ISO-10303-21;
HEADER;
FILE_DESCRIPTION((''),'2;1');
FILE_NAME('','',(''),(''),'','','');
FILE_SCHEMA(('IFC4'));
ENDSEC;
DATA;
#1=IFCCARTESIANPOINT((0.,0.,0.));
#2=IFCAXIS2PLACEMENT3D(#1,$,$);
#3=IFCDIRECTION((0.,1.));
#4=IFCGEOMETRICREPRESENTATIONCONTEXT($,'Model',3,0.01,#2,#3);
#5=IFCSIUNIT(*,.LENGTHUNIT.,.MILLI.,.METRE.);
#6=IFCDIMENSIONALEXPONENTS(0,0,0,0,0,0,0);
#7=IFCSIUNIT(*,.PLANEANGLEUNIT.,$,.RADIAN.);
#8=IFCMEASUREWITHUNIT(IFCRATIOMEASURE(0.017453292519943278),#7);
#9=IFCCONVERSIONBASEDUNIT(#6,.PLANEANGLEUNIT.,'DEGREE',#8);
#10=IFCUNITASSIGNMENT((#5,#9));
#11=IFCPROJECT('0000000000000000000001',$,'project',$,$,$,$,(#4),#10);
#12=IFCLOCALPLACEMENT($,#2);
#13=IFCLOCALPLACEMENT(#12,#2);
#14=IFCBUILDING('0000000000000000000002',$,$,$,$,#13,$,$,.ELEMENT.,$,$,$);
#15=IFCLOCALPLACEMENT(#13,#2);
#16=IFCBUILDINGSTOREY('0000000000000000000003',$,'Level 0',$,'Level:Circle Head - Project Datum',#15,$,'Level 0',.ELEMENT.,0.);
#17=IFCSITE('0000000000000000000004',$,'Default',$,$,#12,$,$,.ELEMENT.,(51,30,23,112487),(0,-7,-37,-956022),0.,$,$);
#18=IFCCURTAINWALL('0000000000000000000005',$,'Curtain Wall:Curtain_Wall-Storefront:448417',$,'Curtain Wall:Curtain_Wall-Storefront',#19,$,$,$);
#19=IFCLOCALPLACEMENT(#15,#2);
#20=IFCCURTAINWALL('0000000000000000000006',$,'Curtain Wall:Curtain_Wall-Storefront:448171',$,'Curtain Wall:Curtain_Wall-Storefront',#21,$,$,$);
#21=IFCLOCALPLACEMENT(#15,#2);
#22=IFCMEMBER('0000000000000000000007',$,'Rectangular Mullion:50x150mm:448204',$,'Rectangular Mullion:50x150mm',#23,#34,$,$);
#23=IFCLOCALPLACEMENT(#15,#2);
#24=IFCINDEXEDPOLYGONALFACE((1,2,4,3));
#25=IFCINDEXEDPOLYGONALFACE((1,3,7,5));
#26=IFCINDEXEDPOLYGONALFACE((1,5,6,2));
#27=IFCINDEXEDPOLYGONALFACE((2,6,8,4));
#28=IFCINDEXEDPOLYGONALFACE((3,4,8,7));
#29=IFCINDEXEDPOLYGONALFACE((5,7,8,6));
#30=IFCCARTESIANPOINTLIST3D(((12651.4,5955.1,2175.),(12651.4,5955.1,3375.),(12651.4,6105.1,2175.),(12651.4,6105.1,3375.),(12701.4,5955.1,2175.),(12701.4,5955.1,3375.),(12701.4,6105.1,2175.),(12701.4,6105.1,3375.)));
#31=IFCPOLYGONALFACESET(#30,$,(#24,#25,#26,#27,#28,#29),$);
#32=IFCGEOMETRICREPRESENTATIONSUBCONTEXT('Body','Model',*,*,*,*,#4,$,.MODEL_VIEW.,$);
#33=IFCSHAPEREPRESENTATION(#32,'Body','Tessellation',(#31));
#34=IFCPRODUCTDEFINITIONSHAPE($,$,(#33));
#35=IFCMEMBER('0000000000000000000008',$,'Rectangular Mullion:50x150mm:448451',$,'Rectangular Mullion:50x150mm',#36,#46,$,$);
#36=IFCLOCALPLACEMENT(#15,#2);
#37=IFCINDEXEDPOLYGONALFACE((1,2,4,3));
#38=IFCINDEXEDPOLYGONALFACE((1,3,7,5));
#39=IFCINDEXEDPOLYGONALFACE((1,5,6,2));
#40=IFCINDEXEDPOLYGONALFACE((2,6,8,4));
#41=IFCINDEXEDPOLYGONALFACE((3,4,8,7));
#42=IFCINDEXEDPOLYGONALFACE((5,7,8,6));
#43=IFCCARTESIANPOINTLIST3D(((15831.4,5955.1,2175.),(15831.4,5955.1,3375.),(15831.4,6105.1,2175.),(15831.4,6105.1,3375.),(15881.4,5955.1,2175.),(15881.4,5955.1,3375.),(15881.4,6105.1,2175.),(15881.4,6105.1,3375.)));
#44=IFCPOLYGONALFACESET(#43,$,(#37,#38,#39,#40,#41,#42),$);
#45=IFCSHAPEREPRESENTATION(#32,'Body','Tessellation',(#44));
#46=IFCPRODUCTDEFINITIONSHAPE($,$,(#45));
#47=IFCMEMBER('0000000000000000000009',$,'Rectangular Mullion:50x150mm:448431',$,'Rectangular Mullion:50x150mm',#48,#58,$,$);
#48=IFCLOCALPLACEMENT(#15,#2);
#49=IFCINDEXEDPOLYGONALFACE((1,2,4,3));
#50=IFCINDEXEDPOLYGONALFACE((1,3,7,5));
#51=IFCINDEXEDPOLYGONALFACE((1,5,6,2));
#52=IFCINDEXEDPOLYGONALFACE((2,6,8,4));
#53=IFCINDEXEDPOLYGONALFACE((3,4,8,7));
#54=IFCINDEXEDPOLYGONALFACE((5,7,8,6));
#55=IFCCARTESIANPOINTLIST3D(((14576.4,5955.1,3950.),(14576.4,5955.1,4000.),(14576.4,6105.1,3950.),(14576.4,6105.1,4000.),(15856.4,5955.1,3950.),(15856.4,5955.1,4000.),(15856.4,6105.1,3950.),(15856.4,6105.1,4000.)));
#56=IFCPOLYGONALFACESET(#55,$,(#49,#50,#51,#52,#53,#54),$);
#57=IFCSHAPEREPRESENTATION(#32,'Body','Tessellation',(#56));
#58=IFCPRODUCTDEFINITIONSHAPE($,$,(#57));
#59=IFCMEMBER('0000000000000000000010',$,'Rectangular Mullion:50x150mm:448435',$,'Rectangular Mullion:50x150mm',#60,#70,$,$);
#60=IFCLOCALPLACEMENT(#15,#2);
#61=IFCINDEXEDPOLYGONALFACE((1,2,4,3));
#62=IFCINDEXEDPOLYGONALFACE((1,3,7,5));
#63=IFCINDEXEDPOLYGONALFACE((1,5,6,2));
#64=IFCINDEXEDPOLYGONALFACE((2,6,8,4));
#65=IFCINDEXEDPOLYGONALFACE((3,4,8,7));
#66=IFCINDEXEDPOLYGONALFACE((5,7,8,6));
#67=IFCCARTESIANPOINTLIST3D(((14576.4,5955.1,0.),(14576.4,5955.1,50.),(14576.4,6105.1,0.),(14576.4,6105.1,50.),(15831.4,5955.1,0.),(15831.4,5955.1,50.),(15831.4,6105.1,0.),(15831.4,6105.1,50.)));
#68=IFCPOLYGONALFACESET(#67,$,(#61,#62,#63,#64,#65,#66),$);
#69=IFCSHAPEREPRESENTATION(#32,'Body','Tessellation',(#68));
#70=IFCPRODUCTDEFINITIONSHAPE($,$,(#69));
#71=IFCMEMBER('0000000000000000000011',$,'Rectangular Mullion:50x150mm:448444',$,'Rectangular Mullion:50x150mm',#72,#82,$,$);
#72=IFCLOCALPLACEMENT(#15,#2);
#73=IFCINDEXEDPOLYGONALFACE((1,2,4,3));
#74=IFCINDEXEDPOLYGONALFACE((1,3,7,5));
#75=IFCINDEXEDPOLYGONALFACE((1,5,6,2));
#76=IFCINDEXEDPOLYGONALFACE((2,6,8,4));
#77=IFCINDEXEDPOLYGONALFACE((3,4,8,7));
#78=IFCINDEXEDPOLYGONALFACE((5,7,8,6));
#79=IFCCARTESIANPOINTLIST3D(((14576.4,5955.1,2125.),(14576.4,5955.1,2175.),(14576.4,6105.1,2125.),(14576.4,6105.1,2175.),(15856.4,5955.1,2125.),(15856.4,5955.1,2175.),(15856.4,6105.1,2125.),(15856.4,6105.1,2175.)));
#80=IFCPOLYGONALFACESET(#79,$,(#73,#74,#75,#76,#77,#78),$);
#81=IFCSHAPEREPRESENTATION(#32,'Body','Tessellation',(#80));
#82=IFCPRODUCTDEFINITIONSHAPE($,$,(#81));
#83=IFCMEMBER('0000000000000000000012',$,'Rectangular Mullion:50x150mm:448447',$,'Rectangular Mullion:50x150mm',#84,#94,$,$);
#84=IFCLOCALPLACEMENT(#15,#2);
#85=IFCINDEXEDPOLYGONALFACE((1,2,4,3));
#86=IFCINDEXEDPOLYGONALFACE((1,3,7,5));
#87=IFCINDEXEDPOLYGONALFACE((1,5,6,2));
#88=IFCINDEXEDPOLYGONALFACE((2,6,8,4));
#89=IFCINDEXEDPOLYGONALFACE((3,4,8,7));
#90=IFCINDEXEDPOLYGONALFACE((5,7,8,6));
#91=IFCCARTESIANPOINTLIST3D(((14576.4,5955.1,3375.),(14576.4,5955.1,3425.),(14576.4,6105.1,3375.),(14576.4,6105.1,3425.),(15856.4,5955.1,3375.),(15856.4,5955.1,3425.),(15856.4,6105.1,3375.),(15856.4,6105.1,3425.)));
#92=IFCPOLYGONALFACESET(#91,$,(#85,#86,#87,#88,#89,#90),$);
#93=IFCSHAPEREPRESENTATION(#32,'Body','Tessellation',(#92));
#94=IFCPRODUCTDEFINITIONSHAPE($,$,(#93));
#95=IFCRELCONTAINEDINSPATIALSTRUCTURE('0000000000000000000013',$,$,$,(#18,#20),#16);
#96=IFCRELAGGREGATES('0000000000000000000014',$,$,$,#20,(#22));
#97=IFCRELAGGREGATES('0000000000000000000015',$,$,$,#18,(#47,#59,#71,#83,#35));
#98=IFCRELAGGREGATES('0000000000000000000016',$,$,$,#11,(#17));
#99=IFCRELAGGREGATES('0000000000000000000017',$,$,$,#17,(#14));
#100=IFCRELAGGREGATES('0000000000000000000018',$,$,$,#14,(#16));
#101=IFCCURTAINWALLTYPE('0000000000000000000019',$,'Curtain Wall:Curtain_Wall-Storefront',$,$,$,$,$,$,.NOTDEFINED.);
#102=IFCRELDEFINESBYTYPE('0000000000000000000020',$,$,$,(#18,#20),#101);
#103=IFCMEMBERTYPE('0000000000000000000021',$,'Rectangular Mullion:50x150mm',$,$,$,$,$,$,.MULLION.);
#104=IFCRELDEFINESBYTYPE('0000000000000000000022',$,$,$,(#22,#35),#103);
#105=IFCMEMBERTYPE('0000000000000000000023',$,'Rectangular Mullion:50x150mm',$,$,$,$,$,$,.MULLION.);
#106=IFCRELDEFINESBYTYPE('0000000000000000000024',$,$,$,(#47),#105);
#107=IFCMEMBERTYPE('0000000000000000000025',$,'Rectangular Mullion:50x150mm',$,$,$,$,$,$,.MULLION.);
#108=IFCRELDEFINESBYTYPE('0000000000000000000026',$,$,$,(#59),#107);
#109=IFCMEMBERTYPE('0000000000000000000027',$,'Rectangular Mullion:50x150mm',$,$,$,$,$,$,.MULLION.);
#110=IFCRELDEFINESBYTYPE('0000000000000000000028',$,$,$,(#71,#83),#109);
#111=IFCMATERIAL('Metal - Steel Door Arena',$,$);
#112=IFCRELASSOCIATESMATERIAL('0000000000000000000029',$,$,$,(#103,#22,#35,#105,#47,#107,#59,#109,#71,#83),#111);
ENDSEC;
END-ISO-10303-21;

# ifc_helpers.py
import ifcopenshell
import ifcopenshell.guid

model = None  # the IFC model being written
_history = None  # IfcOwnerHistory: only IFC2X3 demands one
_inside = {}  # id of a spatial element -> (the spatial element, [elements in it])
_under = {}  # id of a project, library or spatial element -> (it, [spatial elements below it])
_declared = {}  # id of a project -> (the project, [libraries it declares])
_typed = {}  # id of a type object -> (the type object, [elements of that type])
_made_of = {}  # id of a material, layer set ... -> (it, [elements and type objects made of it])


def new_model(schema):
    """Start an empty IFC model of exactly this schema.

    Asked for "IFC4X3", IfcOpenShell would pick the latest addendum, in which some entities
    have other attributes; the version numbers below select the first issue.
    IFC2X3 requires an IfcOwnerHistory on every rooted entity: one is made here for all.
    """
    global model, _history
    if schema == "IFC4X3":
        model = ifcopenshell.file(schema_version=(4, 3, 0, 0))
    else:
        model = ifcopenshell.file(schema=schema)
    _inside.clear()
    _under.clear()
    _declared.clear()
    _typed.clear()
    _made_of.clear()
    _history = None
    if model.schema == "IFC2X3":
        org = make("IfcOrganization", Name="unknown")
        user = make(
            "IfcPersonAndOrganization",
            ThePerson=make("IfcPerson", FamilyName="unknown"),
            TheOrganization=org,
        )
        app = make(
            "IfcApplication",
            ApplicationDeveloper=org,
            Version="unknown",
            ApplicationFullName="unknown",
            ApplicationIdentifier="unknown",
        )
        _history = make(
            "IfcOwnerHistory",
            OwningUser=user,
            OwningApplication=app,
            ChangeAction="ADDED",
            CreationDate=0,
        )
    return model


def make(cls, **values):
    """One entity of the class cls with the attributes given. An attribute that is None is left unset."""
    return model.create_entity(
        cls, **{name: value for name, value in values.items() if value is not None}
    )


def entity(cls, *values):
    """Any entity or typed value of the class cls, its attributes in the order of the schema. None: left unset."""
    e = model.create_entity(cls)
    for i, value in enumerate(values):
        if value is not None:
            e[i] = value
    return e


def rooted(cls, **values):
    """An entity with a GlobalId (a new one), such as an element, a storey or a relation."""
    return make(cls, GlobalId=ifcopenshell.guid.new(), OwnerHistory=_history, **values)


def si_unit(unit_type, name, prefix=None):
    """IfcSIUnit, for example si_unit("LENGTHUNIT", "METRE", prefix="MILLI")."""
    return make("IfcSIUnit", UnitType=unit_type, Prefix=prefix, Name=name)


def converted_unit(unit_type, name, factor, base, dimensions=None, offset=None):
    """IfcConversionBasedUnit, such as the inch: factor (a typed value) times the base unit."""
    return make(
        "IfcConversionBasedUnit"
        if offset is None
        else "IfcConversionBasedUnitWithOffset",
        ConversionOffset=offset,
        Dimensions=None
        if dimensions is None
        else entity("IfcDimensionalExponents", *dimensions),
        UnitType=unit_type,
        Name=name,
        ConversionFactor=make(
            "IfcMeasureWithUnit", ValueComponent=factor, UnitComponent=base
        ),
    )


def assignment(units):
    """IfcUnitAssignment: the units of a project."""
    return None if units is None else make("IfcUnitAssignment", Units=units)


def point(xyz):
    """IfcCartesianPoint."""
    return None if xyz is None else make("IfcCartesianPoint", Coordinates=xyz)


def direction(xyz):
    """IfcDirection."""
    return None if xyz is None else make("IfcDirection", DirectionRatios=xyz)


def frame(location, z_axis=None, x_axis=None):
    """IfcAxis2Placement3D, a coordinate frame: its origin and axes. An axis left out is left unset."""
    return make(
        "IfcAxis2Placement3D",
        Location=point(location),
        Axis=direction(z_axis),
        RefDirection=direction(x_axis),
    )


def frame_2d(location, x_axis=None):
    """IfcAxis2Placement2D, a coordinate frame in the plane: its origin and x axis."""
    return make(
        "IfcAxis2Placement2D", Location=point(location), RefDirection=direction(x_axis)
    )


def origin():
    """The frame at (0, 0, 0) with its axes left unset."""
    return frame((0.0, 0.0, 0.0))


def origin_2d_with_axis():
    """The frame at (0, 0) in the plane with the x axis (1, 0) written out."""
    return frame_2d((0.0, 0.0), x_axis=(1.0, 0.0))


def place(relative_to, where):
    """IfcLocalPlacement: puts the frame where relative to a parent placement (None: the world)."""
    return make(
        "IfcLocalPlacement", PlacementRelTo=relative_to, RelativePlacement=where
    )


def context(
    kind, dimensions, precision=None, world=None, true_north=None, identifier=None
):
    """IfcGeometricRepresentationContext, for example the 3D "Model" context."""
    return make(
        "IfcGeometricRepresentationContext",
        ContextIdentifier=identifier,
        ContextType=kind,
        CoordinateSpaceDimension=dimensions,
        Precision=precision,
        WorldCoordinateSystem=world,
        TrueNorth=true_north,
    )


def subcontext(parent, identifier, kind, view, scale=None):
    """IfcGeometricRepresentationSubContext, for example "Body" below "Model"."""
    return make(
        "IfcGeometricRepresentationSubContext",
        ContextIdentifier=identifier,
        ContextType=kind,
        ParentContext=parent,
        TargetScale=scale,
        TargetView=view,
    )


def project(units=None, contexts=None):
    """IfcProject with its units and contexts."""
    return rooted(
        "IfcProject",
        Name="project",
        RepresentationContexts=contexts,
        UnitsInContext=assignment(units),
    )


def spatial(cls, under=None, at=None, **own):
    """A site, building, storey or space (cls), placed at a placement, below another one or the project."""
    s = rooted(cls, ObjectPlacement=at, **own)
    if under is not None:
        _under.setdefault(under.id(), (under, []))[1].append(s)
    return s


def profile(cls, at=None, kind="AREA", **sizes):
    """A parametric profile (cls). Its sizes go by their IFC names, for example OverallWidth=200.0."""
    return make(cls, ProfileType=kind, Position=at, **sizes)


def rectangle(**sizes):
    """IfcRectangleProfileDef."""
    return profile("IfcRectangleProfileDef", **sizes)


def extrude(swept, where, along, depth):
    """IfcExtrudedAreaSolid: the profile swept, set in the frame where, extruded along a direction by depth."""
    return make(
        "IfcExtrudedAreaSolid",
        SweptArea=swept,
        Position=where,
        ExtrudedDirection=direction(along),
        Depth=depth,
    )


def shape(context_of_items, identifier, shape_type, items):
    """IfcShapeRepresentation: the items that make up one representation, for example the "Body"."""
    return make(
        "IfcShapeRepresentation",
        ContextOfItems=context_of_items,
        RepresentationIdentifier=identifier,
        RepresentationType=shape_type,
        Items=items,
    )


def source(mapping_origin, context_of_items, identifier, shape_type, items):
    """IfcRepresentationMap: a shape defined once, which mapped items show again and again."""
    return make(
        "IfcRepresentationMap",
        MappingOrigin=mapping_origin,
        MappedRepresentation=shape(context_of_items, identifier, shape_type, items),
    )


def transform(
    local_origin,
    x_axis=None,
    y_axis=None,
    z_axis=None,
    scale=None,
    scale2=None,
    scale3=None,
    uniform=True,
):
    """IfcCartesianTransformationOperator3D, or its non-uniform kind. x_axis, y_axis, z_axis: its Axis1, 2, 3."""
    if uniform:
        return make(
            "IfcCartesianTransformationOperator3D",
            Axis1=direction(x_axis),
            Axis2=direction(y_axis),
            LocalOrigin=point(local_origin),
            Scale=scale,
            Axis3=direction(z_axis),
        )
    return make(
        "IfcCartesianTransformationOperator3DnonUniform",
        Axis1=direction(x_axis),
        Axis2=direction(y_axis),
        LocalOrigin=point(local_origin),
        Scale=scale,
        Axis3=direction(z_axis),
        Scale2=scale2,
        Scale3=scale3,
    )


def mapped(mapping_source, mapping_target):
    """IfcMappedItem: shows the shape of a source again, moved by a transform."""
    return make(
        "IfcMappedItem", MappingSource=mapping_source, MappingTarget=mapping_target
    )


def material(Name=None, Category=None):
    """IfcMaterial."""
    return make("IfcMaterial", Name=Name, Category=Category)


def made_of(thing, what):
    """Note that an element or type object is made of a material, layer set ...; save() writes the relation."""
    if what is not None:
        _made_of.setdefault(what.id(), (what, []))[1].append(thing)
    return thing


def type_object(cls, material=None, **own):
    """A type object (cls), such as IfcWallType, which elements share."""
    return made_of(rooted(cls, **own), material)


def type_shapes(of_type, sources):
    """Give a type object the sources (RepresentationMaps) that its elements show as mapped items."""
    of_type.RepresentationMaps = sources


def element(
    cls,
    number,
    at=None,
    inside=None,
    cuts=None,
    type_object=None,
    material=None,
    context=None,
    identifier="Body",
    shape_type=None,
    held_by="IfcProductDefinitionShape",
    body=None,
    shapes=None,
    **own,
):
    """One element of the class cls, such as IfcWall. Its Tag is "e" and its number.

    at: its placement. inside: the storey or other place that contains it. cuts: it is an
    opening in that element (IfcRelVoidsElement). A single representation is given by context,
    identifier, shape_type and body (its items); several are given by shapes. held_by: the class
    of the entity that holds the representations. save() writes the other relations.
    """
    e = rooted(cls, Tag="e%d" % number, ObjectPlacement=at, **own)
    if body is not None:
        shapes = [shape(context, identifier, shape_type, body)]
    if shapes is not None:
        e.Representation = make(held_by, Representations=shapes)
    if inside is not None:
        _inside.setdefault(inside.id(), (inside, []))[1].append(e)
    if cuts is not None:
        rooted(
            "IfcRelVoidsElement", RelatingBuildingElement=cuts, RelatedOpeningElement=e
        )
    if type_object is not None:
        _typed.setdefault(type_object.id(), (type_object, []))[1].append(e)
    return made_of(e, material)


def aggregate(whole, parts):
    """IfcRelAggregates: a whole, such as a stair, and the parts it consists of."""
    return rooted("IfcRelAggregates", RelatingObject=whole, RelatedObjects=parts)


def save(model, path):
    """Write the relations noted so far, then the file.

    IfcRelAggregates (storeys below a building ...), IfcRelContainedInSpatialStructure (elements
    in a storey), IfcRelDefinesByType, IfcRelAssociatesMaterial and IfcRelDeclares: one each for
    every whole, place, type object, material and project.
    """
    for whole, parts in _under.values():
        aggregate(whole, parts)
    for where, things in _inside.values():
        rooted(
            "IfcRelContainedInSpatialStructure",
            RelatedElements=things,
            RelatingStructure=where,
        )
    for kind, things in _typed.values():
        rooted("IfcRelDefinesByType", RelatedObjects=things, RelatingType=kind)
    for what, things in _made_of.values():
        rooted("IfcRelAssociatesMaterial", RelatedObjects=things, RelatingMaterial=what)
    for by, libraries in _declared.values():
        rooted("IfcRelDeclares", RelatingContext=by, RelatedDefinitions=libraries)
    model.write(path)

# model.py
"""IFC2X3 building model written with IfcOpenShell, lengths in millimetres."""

from ifc_helpers import new_model, entity, si_unit, converted_unit, direction, frame, origin, origin_2d_with_axis, place, context, subcontext, project, spatial, rectangle, extrude, source, transform, mapped, material, type_object, type_shapes, element, aggregate, save


model = new_model("IFC2X3")

# Units and contexts
model_context = context("Model", 3, precision=0.01, world=origin(), true_north=direction((0.0, 1.0)))
body_context = subcontext(model_context, "Body", "Model", "MODEL_VIEW")
ifc_project = project(units=[si_unit("LENGTHUNIT", "METRE", prefix="MILLI"), converted_unit("PLANEANGLEUNIT", "DEGREE", entity("IfcRatioMeasure", 0.017453292519943278), si_unit("PLANEANGLEUNIT", "RADIAN"), dimensions=[0, 0, 0, 0, 0, 0, 0])], contexts=[model_context])

# Site, building, storey
site_placement = place(None, origin())
site = spatial("IfcSite", under=ifc_project, at=site_placement, Name="Default", CompositionType="ELEMENT", RefLatitude=(51, 30, 23, 112487), RefLongitude=(0, -7, -37, -956022), RefElevation=0.0)
building_placement = place(site_placement, origin())
building = spatial("IfcBuilding", under=site, at=building_placement, CompositionType="ELEMENT")
storey_placement = place(building_placement, origin())
storey = spatial("IfcBuildingStorey", under=building, at=storey_placement, Name="Level 0", ObjectType="Level:Circle Head - Project Datum", LongName="Level 0", CompositionType="ELEMENT", Elevation=0.0)

# Curtain walls
curtain_wall_type = type_object("IfcCurtainWallType", Name="Curtain Wall:Curtain_Wall-Storefront", PredefinedType="NOTDEFINED")
curtain_wall_1_placement = place(storey_placement, origin())
curtain_wall_1 = element("IfcCurtainWall", 1, at=curtain_wall_1_placement, inside=storey, type_object=curtain_wall_type, Name="Curtain Wall:Curtain_Wall-Storefront:448417", ObjectType="Curtain Wall:Curtain_Wall-Storefront")
ifc_material_1 = material(Name="Metal - Steel Door Arena")
curtain_wall_2_placement = place(storey_placement, origin())
curtain_wall_2 = element("IfcCurtainWall", 2, at=curtain_wall_2_placement, inside=storey, type_object=curtain_wall_type, Name="Curtain Wall:Curtain_Wall-Storefront:448171", ObjectType="Curtain Wall:Curtain_Wall-Storefront")

# Members
member_type_1 = type_object("IfcMemberType", Name="Rectangular Mullion:50x150mm", PredefinedType="MULLION", material=ifc_material_1)
shared_shape_1 = source(origin(), body_context, "Body", "SweptSolid", [
    extrude(rectangle(XDim=150.0, YDim=50.0, at=origin_2d_with_axis()), frame((0.0, 0.0, -1200.0), z_axis=(0.0, 0.0, 1.0), x_axis=(0.0, -1.0, 0.0)), (0.0, 0.0, 1.0), 1200.0),
])
type_shapes(member_type_1, [shared_shape_1])
member_1_placement = place(curtain_wall_2_placement, frame((12676.4, 6030.1, 2175.0), z_axis=(0.0, 0.0, -1.0), x_axis=(-1.0, 0.0, 0.0)))
member_1 = element("IfcMember", 3, at=member_1_placement, type_object=member_type_1, material=ifc_material_1, Name="Rectangular Mullion:50x150mm:448204", ObjectType="Rectangular Mullion:50x150mm", context=body_context, shape_type="MappedRepresentation", body=[
    mapped(shared_shape_1, transform((0.0, 0.0, 0.0), scale=1.0)),
])
member_2_placement = place(curtain_wall_1_placement, frame((15856.4, 6030.1, 2175.0), z_axis=(0.0, 0.0, -1.0), x_axis=(-1.0, 0.0, 0.0)))
member_2 = element("IfcMember", 4, at=member_2_placement, type_object=member_type_1, material=ifc_material_1, Name="Rectangular Mullion:50x150mm:448451", ObjectType="Rectangular Mullion:50x150mm", context=body_context, shape_type="MappedRepresentation", body=[
    mapped(shared_shape_1, transform((0.0, 0.0, 0.0), scale=1.0)),
])
member_type_2 = type_object("IfcMemberType", Name="Rectangular Mullion:50x150mm", PredefinedType="MULLION", material=ifc_material_1)
shared_shape_2 = source(origin(), body_context, "Body", "SweptSolid", [
    extrude(rectangle(XDim=150.0, YDim=50.0, at=origin_2d_with_axis()), frame((-25.0, 0.0, -1280.0), z_axis=(0.0, 0.0, 1.0), x_axis=(0.0, -1.0, 0.0)), (0.0, 0.0, 1.0), 1280.0),
])
type_shapes(member_type_2, [shared_shape_2])
member_3_placement = place(curtain_wall_1_placement, frame((14576.4, 6030.1, 4000.0), z_axis=(-1.0, 0.0, 0.0), x_axis=(0.0, 0.0, 1.0)))
member_3 = element("IfcMember", 5, at=member_3_placement, type_object=member_type_2, material=ifc_material_1, Name="Rectangular Mullion:50x150mm:448431", ObjectType="Rectangular Mullion:50x150mm", context=body_context, shape_type="MappedRepresentation", body=[
    mapped(shared_shape_2, transform((0.0, 0.0, 0.0), scale=1.0)),
])
member_type_3 = type_object("IfcMemberType", Name="Rectangular Mullion:50x150mm", PredefinedType="MULLION", material=ifc_material_1)
shared_shape_3 = source(origin(), body_context, "Body", "SweptSolid", [
    extrude(rectangle(XDim=150.0, YDim=50.0, at=origin_2d_with_axis()), frame((-25.0, 0.0, -1255.0), z_axis=(0.0, 0.0, 1.0), x_axis=(0.0, -1.0, 0.0)), (0.0, 0.0, 1.0), 1255.0),
])
type_shapes(member_type_3, [shared_shape_3])
member_4_placement = place(curtain_wall_1_placement, frame((15831.4, 6030.1, 0.0), z_axis=(1.0, 0.0, 0.0), x_axis=(0.0, 0.0, -1.0)))
member_4 = element("IfcMember", 6, at=member_4_placement, type_object=member_type_3, material=ifc_material_1, Name="Rectangular Mullion:50x150mm:448435", ObjectType="Rectangular Mullion:50x150mm", context=body_context, shape_type="MappedRepresentation", body=[
    mapped(shared_shape_3, transform((0.0, 0.0, 0.0), scale=1.0)),
])
member_type_4 = type_object("IfcMemberType", Name="Rectangular Mullion:50x150mm", PredefinedType="MULLION", material=ifc_material_1)
shared_shape_4 = source(origin(), body_context, "Body", "SweptSolid", [
    extrude(rectangle(XDim=150.0, YDim=50.0, at=origin_2d_with_axis()), frame((0.0, 0.0, -1280.0), z_axis=(0.0, 0.0, 1.0), x_axis=(0.0, -1.0, 0.0)), (0.0, 0.0, 1.0), 1280.0),
])
type_shapes(member_type_4, [shared_shape_4])
member_5_placement = place(curtain_wall_1_placement, frame((14576.4, 6030.1, 2150.0), z_axis=(-1.0, 0.0, 0.0), x_axis=(0.0, 0.0, 1.0)))
member_5 = element("IfcMember", 7, at=member_5_placement, type_object=member_type_4, material=ifc_material_1, Name="Rectangular Mullion:50x150mm:448444", ObjectType="Rectangular Mullion:50x150mm", context=body_context, shape_type="MappedRepresentation", body=[
    mapped(shared_shape_4, transform((0.0, 0.0, 0.0), scale=1.0)),
])
member_6_placement = place(curtain_wall_1_placement, frame((14576.4, 6030.1, 3400.0), z_axis=(-1.0, 0.0, 0.0), x_axis=(0.0, 0.0, 1.0)))
member_6 = element("IfcMember", 8, at=member_6_placement, type_object=member_type_4, material=ifc_material_1, Name="Rectangular Mullion:50x150mm:448447", ObjectType="Rectangular Mullion:50x150mm", context=body_context, shape_type="MappedRepresentation", body=[
    mapped(shared_shape_4, transform((0.0, 0.0, 0.0), scale=1.0)),
])

aggregate(curtain_wall_2, [member_1])
aggregate(curtain_wall_1, [member_3, member_4, member_5, member_6, member_2])

save(model, "model.ifc")
